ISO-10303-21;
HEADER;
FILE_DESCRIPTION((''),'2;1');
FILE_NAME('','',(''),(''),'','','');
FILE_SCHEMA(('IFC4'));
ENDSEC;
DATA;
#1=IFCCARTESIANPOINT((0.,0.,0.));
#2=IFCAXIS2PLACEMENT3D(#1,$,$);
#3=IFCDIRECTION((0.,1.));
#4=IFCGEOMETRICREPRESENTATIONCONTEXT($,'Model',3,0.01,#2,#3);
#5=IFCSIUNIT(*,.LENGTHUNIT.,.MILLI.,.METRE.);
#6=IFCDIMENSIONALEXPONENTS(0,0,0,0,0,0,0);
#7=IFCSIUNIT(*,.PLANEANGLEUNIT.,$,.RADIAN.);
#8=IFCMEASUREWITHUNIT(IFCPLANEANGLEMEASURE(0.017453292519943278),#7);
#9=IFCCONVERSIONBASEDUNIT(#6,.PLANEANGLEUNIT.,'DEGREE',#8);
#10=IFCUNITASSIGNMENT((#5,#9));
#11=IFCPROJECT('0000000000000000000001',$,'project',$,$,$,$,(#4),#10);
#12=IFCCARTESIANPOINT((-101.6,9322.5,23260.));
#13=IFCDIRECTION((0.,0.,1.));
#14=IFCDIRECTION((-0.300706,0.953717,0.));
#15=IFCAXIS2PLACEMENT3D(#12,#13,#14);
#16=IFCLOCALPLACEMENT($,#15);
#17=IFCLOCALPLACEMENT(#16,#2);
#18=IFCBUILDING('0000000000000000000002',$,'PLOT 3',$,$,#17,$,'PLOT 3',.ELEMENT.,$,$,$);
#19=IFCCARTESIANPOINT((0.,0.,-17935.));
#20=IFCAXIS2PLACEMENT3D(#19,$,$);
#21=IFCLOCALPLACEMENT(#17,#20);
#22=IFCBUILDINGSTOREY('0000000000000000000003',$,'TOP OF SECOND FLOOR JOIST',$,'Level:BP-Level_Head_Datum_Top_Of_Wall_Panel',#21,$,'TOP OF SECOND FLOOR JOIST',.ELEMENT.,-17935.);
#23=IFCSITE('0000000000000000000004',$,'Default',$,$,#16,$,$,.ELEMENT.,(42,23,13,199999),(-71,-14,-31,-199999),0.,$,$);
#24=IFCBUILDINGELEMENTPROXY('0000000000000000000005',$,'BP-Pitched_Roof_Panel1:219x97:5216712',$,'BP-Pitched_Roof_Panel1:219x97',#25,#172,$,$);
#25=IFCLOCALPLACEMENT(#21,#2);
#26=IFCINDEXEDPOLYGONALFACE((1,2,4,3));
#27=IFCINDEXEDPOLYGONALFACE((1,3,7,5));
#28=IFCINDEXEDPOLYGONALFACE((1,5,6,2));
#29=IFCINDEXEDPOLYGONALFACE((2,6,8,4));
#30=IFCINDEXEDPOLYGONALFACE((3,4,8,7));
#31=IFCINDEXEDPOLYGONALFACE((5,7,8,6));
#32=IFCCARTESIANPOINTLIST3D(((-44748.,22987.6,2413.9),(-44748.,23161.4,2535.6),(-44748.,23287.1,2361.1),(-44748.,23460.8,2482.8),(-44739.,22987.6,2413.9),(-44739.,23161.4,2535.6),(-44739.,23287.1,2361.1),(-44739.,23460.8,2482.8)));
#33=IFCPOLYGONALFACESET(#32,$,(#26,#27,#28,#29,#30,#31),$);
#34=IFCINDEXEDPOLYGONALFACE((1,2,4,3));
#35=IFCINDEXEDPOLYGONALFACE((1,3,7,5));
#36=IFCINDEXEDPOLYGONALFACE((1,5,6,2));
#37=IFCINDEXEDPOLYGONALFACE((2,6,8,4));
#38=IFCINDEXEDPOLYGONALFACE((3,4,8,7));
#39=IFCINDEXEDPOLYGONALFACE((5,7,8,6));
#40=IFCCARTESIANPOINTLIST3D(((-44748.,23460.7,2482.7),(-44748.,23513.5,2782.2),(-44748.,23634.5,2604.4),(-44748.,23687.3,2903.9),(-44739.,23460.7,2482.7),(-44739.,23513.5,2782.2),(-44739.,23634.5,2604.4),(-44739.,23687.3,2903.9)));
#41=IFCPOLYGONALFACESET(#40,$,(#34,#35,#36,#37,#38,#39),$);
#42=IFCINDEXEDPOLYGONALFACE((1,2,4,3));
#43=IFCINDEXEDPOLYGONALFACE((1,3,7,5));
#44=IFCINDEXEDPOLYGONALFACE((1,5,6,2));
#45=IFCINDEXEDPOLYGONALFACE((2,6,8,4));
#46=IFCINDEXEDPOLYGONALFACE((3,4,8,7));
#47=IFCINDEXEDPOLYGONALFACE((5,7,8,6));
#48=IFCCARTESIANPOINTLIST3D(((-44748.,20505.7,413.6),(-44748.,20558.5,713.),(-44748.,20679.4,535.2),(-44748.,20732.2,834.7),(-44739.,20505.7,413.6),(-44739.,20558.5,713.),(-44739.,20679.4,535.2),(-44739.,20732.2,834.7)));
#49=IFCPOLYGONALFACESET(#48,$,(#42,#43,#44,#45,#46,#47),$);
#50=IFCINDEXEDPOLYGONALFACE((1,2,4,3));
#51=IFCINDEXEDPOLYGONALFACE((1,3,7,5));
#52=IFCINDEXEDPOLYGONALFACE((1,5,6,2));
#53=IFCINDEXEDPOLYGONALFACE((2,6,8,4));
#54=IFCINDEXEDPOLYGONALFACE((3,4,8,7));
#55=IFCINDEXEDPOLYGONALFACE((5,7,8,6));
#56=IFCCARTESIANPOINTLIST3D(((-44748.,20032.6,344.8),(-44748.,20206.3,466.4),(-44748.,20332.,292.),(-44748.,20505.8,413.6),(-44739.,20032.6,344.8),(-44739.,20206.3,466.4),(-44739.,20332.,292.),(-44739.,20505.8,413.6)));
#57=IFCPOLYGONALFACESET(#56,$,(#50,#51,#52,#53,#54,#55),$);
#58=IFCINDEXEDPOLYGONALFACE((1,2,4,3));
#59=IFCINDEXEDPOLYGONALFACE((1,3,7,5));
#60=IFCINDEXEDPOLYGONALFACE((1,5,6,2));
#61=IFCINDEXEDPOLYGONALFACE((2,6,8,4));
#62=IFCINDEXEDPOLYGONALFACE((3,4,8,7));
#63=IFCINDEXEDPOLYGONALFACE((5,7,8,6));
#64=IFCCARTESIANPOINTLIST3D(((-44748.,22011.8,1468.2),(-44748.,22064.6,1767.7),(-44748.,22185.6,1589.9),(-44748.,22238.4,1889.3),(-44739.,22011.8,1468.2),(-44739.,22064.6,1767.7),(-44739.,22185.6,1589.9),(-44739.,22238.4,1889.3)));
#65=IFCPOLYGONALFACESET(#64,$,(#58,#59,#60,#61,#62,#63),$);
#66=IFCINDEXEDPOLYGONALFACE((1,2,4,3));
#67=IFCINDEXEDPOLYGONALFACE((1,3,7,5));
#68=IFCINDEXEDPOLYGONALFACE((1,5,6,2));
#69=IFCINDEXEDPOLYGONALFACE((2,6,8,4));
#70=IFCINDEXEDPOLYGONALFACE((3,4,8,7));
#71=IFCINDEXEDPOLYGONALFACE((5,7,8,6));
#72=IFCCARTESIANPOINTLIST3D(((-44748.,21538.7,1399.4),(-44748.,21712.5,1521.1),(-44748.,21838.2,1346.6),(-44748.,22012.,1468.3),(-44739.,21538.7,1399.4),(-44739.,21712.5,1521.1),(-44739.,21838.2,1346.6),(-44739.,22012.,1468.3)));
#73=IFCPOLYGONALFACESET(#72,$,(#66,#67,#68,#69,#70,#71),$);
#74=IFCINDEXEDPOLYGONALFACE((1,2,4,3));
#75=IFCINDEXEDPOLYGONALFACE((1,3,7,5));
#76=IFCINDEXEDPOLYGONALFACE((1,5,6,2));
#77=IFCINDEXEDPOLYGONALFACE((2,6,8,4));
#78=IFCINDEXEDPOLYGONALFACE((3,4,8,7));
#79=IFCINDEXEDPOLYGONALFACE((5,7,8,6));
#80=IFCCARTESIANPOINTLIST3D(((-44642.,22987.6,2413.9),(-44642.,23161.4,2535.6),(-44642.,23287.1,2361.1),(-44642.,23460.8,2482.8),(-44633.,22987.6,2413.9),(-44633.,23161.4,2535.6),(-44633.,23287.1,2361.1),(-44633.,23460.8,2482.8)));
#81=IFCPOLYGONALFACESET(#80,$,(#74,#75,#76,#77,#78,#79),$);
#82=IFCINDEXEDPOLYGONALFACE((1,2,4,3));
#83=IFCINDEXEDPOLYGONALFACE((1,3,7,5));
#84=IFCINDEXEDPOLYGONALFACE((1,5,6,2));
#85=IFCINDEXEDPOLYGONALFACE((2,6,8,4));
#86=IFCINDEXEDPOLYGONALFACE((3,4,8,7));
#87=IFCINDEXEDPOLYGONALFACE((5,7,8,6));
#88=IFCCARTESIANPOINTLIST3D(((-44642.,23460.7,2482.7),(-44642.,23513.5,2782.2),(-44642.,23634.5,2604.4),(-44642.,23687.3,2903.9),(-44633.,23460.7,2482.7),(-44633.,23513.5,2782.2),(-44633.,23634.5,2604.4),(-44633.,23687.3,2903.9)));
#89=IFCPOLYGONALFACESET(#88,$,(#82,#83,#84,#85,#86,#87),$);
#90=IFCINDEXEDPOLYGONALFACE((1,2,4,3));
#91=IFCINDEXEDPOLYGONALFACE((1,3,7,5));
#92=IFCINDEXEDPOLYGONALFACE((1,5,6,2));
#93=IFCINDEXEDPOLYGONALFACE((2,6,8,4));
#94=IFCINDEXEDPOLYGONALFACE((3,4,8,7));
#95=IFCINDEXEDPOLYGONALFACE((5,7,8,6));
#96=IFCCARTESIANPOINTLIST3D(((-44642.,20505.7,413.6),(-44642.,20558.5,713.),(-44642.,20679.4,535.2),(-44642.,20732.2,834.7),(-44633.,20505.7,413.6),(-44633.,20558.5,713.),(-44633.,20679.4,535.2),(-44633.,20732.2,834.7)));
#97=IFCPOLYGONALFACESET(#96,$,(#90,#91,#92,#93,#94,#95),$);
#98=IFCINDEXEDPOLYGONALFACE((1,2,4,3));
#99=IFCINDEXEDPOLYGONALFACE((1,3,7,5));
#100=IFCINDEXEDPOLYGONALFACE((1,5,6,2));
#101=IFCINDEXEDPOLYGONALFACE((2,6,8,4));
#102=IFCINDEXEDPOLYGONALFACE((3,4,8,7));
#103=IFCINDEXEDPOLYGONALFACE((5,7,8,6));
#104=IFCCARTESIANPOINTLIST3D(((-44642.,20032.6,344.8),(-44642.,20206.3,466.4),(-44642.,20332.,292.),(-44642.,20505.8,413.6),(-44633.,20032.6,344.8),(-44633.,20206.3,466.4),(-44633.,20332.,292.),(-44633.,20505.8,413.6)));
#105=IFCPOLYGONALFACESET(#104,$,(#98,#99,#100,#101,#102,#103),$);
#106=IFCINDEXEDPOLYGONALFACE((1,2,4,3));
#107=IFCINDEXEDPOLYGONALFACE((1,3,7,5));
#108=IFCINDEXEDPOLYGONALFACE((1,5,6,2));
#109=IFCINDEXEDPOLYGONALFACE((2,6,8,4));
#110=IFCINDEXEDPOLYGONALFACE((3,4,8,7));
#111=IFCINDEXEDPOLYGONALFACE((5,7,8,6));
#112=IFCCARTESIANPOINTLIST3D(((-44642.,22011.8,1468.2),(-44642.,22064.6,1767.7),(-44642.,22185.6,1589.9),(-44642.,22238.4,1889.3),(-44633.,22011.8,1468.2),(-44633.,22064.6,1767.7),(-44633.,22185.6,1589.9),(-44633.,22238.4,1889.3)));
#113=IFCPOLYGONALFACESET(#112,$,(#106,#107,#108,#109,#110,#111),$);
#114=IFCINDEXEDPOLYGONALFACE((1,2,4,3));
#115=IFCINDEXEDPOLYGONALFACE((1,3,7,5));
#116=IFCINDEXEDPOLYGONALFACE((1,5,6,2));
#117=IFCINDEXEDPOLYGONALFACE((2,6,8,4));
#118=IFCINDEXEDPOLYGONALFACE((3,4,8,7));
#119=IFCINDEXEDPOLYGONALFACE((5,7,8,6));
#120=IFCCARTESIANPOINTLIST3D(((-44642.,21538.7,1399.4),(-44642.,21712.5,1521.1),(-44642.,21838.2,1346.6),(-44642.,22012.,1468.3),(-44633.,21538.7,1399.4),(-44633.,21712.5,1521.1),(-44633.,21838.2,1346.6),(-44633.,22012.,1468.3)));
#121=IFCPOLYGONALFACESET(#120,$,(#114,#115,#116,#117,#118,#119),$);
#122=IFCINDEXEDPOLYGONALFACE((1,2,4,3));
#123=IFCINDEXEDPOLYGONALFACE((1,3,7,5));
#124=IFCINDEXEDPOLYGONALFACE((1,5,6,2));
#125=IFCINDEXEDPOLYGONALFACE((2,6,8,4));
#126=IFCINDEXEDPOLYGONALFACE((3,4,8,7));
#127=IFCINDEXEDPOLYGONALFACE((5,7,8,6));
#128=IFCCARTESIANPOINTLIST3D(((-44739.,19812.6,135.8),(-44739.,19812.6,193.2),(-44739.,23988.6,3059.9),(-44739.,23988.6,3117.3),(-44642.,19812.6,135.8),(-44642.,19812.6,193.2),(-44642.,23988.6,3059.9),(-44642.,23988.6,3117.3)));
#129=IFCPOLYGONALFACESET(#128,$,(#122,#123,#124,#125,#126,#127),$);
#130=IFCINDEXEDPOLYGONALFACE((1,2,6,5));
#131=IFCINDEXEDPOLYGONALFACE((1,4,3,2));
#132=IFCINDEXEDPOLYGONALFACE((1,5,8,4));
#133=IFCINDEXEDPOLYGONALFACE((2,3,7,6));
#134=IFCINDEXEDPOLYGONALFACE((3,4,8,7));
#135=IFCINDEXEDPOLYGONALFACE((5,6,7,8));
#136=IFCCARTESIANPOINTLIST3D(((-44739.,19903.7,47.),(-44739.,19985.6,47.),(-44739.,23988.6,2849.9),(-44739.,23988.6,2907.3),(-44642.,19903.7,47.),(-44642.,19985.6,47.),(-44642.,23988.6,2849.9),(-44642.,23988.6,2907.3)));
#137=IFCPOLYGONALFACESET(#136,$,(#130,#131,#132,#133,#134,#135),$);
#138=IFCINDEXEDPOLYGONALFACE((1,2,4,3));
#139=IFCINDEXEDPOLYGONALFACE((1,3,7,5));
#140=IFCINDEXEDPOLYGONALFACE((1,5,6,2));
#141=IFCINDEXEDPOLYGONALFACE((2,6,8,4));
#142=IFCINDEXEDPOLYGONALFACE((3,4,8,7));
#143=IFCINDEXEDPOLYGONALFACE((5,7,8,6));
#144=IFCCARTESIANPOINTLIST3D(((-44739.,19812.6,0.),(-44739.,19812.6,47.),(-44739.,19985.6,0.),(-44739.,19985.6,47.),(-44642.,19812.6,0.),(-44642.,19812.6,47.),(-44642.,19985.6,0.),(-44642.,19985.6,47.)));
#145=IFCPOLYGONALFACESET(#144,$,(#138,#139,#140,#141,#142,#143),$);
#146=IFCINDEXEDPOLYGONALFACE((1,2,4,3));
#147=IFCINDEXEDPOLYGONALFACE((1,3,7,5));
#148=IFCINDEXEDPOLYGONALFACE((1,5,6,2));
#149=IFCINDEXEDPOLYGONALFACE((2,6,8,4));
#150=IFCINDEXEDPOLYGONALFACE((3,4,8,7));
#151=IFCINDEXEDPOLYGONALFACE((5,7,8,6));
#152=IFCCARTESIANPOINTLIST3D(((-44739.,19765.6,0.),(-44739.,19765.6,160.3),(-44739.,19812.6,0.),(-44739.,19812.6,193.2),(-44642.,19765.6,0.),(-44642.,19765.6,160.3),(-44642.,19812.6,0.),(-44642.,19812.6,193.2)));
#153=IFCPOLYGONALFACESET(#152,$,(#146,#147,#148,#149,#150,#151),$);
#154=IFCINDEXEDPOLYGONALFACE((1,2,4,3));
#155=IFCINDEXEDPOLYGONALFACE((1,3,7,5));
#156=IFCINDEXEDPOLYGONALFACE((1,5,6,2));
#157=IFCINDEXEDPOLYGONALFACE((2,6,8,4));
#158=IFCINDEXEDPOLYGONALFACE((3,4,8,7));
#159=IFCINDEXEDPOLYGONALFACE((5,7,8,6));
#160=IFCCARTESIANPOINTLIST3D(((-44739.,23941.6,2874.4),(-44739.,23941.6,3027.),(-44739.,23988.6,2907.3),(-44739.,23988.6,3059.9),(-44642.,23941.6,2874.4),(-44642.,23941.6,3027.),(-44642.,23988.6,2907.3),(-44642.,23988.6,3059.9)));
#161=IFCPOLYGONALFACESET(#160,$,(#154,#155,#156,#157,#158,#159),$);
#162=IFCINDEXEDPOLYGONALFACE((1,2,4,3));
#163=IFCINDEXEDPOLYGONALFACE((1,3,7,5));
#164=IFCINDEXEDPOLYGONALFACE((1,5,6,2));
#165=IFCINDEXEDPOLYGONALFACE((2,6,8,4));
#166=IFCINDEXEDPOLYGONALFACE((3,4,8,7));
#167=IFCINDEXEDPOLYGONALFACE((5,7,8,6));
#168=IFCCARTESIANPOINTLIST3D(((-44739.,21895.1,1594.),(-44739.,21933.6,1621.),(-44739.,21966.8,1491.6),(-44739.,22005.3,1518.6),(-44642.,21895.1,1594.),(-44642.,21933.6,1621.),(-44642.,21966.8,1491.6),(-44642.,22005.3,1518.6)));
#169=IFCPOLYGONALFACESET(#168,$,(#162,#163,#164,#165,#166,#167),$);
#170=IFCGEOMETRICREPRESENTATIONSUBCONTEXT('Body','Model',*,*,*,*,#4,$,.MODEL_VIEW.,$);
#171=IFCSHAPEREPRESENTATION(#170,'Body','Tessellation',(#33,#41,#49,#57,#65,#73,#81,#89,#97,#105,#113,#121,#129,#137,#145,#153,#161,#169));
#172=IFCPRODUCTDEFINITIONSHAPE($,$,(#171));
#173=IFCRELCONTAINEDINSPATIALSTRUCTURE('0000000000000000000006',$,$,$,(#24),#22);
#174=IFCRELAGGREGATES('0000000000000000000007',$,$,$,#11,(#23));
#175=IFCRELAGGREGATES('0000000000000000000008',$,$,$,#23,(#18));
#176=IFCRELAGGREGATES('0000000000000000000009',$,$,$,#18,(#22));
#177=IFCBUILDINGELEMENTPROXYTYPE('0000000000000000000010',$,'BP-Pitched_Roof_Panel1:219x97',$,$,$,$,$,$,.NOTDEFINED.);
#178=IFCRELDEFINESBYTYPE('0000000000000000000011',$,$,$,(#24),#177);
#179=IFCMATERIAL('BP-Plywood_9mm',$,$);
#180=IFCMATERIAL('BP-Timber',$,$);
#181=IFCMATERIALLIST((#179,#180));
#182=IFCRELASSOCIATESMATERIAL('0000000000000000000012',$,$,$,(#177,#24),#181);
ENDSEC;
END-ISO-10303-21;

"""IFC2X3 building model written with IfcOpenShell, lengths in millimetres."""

from ifc_helpers import new_model, entity, si_unit, converted_unit, direction, frame, frame_2d, origin, origin_2d_with_axis, place, context, subcontext, project, spatial, polyline, rectangle, outline, extrude, source, transform, mapped, material, material_list, type_object, type_shapes, element, save


model = new_model("IFC2X3")

# Units and contexts
model_context = context("Model", 3, precision=0.01, world=origin(), true_north=direction((0.0, 1.0)))
body_context = subcontext(model_context, "Body", "Model", "MODEL_VIEW")
ifc_project = project(units=[si_unit("LENGTHUNIT", "METRE", prefix="MILLI"), converted_unit("PLANEANGLEUNIT", "DEGREE", entity("IfcPlaneAngleMeasure", 0.017453292519943278), si_unit("PLANEANGLEUNIT", "RADIAN"), dimensions=[0, 0, 0, 0, 0, 0, 0])], contexts=[model_context])

# Site, building, storey
site_placement = place(None, frame((-101.6, 9322.5, 23260.0), z_axis=(0.0, 0.0, 1.0), x_axis=(-0.300706, 0.953717, 0.0)))
site = spatial("IfcSite", under=ifc_project, at=site_placement, Name="Default", CompositionType="ELEMENT", RefLatitude=(42, 23, 13, 199999), RefLongitude=(-71, -14, -31, -199999), RefElevation=0.0)
building_placement = place(site_placement, origin())
building = spatial("IfcBuilding", under=site, at=building_placement, Name="PLOT 3", LongName="PLOT 3", CompositionType="ELEMENT")
storey_placement = place(building_placement, frame((0.0, 0.0, -17935.0)))
storey = spatial("IfcBuildingStorey", under=building, at=storey_placement, Name="TOP OF SECOND FLOOR JOIST", ObjectType="Level:BP-Level_Head_Datum_Top_Of_Wall_Panel", LongName="TOP OF SECOND FLOOR JOIST", CompositionType="ELEMENT", Elevation=-17935.0)

# Building element proxy
ifc_material_1 = material(Name="BP-Timber")
ifc_material_2 = material(Name="BP-Plywood_9mm")
ifc_material_list = material_list([ifc_material_2, ifc_material_1])
building_element_proxy_type_1 = type_object("IfcBuildingElementProxyType", Name="BP-Pitched_Roof_Panel1:219x97", PredefinedType="NOTDEFINED", material=ifc_material_list)
shared_shape_1 = source(origin(), body_context, "Body", "SweptSolid", [
    extrude(outline(polyline([(-77.0, -75.0), (227.0, -75.0), (77.0, 75.0), (-227.0, 75.0), (-77.0, -75.0)])), frame((36.3, 3947.0, 2448.4), z_axis=(0.0, 1.0, 0.0), x_axis=(-0.984808, 0.0, 0.173648)), (0.0, 0.0, 1.0), 9.0),
    extrude(outline(polyline([(1.4, -107.5), (213.6, -107.5), (-1.4, 107.5), (-213.6, 107.5), (1.4, -107.5)])), frame((386.1, 3947.0, 2693.3), z_axis=(0.0, 1.0, 0.0), x_axis=(-0.819152, 0.0, -0.573576)), (0.0, 0.0, 1.0), 9.0),
    extrude(outline(polyline([(1.4, -107.5), (213.6, -107.5), (-1.4, 107.5), (-213.6, 107.5), (1.4, -107.5)])), frame((-2569.0, 3947.0, 624.1), z_axis=(0.0, 1.0, 0.0), x_axis=(-0.819152, 0.0, -0.573576)), (0.0, 0.0, 1.0), 9.0),
    extrude(outline(polyline([(-77.0, -75.0), (227.0, -75.0), (77.0, 75.0), (-227.0, 75.0), (-77.0, -75.0)])), frame((-2918.8, 3947.0, 379.2), z_axis=(0.0, 1.0, 0.0), x_axis=(-0.984808, 0.0, 0.173648)), (0.0, 0.0, 1.0), 9.0),
    extrude(outline(polyline([(1.4, -107.5), (213.6, -107.5), (-1.4, 107.5), (-213.6, 107.5), (1.4, -107.5)])), frame((-1062.8, 3947.0, 1678.8), z_axis=(0.0, 1.0, 0.0), x_axis=(-0.819152, 0.0, -0.573576)), (0.0, 0.0, 1.0), 9.0),
    extrude(outline(polyline([(-77.0, -75.0), (227.0, -75.0), (77.0, 75.0), (-227.0, 75.0), (-77.0, -75.0)])), frame((-1412.6, 3947.0, 1433.9), z_axis=(0.0, 1.0, 0.0), x_axis=(-0.984808, 0.0, 0.173648)), (0.0, 0.0, 1.0), 9.0),
    extrude(outline(polyline([(-77.0, -75.0), (227.0, -75.0), (77.0, 75.0), (-227.0, 75.0), (-77.0, -75.0)])), frame((36.3, 3841.0, 2448.4), z_axis=(0.0, 1.0, 0.0), x_axis=(-0.984808, 0.0, 0.173648)), (0.0, 0.0, 1.0), 9.0),
    extrude(outline(polyline([(1.4, -107.5), (213.6, -107.5), (-1.4, 107.5), (-213.6, 107.5), (1.4, -107.5)])), frame((386.1, 3841.0, 2693.3), z_axis=(0.0, 1.0, 0.0), x_axis=(-0.819152, 0.0, -0.573576)), (0.0, 0.0, 1.0), 9.0),
    extrude(outline(polyline([(1.4, -107.5), (213.6, -107.5), (-1.4, 107.5), (-213.6, 107.5), (1.4, -107.5)])), frame((-2569.0, 3841.0, 624.1), z_axis=(0.0, 1.0, 0.0), x_axis=(-0.819152, 0.0, -0.573576)), (0.0, 0.0, 1.0), 9.0),
    extrude(outline(polyline([(-77.0, -75.0), (227.0, -75.0), (77.0, 75.0), (-227.0, 75.0), (-77.0, -75.0)])), frame((-2918.8, 3841.0, 379.2), z_axis=(0.0, 1.0, 0.0), x_axis=(-0.984808, 0.0, 0.173648)), (0.0, 0.0, 1.0), 9.0),
    extrude(outline(polyline([(1.4, -107.5), (213.6, -107.5), (-1.4, 107.5), (-213.6, 107.5), (1.4, -107.5)])), frame((-1062.8, 3841.0, 1678.8), z_axis=(0.0, 1.0, 0.0), x_axis=(-0.819152, 0.0, -0.573576)), (0.0, 0.0, 1.0), 9.0),
    extrude(outline(polyline([(-77.0, -75.0), (227.0, -75.0), (77.0, 75.0), (-227.0, 75.0), (-77.0, -75.0)])), frame((-1412.6, 3841.0, 1433.9), z_axis=(0.0, 1.0, 0.0), x_axis=(-0.984808, 0.0, 0.173648)), (0.0, 0.0, 1.0), 9.0),
    extrude(outline(polyline([(-1490.7, -2088.0), (-1433.3, -2088.0), (1490.7, 2088.0), (1433.3, 2088.0), (-1490.7, -2088.0)])), frame((-1287.3, 3850.0, 1626.6), z_axis=(0.0, 1.0, 0.0), x_axis=(0.0, 0.0, -1.0)), (0.0, 0.0, 1.0), 97.0),
    extrude(outline(polyline([(-1444.5, -2022.0), (-1387.1, -2022.0), (1415.8, 1981.0), (1415.8, 2063.0), (-1444.5, -2022.0)])), frame((-1221.3, 3850.0, 1462.8), z_axis=(0.0, 1.0, 0.0), x_axis=(0.0, 0.0, -1.0)), (0.0, 0.0, 1.0), 97.0),
    extrude(rectangle(XDim=97.0, YDim=173.0, at=origin_2d_with_axis()), frame((-3288.8, 3898.5, 0.0), z_axis=(0.0, 0.0, 1.0), x_axis=(0.0, 1.0, 0.0)), (0.0, 0.0, 1.0), 47.0),
    extrude(outline(polyline([(22.0, -72.4), (79.4, -72.4), (-31.4, 85.9), (-69.9, 58.9), (22.0, -72.4)])), frame((-3398.8, 3850.0, 88.4), z_axis=(0.0, 1.0, 0.0), x_axis=(0.819152, 0.0, 0.573576)), (0.0, 0.0, 1.0), 97.0),
    extrude(outline(polyline([(15.1, -62.5), (72.5, -62.5), (-15.1, 62.5), (-72.5, 62.5), (15.1, -62.5)])), frame((777.2, 3850.0, 2967.2), z_axis=(0.0, 1.0, 0.0), x_axis=(0.819152, 0.0, 0.573576)), (0.0, 0.0, 1.0), 97.0),
    extrude(rectangle(XDim=47.0, YDim=97.0, at=frame_2d((0.0, 0.0), x_axis=(0.0, 1.0))), frame((-1201.9, 3898.5, 1505.1), z_axis=(-0.573576, 0.0, 0.819152), x_axis=(0.0, 1.0, 0.0)), (0.0, 0.0, 1.0), 125.0),
])
type_shapes(building_element_proxy_type_1, [shared_shape_1])
for number, where, z_axis, x_axis, name in (
    (1, (-40792.0, 23187.9, 0.0), (0.0, 0.0, 1.0), (0.0, 1.0, 0.0), "BP-Pitched_Roof_Panel1:219x97:5216712"),
):
    element("IfcBuildingElementProxy", number, at=place(storey_placement, frame(where, z_axis=z_axis, x_axis=x_axis)), inside=storey, type_object=building_element_proxy_type_1, material=ifc_material_list, Name=name, ObjectType="BP-Pitched_Roof_Panel1:219x97", context=body_context, shape_type="MappedRepresentation", body=[
        mapped(shared_shape_1, transform((0.0, 0.0, 0.0), scale=1.0)),
    ])

save(model, "model.ifc")
